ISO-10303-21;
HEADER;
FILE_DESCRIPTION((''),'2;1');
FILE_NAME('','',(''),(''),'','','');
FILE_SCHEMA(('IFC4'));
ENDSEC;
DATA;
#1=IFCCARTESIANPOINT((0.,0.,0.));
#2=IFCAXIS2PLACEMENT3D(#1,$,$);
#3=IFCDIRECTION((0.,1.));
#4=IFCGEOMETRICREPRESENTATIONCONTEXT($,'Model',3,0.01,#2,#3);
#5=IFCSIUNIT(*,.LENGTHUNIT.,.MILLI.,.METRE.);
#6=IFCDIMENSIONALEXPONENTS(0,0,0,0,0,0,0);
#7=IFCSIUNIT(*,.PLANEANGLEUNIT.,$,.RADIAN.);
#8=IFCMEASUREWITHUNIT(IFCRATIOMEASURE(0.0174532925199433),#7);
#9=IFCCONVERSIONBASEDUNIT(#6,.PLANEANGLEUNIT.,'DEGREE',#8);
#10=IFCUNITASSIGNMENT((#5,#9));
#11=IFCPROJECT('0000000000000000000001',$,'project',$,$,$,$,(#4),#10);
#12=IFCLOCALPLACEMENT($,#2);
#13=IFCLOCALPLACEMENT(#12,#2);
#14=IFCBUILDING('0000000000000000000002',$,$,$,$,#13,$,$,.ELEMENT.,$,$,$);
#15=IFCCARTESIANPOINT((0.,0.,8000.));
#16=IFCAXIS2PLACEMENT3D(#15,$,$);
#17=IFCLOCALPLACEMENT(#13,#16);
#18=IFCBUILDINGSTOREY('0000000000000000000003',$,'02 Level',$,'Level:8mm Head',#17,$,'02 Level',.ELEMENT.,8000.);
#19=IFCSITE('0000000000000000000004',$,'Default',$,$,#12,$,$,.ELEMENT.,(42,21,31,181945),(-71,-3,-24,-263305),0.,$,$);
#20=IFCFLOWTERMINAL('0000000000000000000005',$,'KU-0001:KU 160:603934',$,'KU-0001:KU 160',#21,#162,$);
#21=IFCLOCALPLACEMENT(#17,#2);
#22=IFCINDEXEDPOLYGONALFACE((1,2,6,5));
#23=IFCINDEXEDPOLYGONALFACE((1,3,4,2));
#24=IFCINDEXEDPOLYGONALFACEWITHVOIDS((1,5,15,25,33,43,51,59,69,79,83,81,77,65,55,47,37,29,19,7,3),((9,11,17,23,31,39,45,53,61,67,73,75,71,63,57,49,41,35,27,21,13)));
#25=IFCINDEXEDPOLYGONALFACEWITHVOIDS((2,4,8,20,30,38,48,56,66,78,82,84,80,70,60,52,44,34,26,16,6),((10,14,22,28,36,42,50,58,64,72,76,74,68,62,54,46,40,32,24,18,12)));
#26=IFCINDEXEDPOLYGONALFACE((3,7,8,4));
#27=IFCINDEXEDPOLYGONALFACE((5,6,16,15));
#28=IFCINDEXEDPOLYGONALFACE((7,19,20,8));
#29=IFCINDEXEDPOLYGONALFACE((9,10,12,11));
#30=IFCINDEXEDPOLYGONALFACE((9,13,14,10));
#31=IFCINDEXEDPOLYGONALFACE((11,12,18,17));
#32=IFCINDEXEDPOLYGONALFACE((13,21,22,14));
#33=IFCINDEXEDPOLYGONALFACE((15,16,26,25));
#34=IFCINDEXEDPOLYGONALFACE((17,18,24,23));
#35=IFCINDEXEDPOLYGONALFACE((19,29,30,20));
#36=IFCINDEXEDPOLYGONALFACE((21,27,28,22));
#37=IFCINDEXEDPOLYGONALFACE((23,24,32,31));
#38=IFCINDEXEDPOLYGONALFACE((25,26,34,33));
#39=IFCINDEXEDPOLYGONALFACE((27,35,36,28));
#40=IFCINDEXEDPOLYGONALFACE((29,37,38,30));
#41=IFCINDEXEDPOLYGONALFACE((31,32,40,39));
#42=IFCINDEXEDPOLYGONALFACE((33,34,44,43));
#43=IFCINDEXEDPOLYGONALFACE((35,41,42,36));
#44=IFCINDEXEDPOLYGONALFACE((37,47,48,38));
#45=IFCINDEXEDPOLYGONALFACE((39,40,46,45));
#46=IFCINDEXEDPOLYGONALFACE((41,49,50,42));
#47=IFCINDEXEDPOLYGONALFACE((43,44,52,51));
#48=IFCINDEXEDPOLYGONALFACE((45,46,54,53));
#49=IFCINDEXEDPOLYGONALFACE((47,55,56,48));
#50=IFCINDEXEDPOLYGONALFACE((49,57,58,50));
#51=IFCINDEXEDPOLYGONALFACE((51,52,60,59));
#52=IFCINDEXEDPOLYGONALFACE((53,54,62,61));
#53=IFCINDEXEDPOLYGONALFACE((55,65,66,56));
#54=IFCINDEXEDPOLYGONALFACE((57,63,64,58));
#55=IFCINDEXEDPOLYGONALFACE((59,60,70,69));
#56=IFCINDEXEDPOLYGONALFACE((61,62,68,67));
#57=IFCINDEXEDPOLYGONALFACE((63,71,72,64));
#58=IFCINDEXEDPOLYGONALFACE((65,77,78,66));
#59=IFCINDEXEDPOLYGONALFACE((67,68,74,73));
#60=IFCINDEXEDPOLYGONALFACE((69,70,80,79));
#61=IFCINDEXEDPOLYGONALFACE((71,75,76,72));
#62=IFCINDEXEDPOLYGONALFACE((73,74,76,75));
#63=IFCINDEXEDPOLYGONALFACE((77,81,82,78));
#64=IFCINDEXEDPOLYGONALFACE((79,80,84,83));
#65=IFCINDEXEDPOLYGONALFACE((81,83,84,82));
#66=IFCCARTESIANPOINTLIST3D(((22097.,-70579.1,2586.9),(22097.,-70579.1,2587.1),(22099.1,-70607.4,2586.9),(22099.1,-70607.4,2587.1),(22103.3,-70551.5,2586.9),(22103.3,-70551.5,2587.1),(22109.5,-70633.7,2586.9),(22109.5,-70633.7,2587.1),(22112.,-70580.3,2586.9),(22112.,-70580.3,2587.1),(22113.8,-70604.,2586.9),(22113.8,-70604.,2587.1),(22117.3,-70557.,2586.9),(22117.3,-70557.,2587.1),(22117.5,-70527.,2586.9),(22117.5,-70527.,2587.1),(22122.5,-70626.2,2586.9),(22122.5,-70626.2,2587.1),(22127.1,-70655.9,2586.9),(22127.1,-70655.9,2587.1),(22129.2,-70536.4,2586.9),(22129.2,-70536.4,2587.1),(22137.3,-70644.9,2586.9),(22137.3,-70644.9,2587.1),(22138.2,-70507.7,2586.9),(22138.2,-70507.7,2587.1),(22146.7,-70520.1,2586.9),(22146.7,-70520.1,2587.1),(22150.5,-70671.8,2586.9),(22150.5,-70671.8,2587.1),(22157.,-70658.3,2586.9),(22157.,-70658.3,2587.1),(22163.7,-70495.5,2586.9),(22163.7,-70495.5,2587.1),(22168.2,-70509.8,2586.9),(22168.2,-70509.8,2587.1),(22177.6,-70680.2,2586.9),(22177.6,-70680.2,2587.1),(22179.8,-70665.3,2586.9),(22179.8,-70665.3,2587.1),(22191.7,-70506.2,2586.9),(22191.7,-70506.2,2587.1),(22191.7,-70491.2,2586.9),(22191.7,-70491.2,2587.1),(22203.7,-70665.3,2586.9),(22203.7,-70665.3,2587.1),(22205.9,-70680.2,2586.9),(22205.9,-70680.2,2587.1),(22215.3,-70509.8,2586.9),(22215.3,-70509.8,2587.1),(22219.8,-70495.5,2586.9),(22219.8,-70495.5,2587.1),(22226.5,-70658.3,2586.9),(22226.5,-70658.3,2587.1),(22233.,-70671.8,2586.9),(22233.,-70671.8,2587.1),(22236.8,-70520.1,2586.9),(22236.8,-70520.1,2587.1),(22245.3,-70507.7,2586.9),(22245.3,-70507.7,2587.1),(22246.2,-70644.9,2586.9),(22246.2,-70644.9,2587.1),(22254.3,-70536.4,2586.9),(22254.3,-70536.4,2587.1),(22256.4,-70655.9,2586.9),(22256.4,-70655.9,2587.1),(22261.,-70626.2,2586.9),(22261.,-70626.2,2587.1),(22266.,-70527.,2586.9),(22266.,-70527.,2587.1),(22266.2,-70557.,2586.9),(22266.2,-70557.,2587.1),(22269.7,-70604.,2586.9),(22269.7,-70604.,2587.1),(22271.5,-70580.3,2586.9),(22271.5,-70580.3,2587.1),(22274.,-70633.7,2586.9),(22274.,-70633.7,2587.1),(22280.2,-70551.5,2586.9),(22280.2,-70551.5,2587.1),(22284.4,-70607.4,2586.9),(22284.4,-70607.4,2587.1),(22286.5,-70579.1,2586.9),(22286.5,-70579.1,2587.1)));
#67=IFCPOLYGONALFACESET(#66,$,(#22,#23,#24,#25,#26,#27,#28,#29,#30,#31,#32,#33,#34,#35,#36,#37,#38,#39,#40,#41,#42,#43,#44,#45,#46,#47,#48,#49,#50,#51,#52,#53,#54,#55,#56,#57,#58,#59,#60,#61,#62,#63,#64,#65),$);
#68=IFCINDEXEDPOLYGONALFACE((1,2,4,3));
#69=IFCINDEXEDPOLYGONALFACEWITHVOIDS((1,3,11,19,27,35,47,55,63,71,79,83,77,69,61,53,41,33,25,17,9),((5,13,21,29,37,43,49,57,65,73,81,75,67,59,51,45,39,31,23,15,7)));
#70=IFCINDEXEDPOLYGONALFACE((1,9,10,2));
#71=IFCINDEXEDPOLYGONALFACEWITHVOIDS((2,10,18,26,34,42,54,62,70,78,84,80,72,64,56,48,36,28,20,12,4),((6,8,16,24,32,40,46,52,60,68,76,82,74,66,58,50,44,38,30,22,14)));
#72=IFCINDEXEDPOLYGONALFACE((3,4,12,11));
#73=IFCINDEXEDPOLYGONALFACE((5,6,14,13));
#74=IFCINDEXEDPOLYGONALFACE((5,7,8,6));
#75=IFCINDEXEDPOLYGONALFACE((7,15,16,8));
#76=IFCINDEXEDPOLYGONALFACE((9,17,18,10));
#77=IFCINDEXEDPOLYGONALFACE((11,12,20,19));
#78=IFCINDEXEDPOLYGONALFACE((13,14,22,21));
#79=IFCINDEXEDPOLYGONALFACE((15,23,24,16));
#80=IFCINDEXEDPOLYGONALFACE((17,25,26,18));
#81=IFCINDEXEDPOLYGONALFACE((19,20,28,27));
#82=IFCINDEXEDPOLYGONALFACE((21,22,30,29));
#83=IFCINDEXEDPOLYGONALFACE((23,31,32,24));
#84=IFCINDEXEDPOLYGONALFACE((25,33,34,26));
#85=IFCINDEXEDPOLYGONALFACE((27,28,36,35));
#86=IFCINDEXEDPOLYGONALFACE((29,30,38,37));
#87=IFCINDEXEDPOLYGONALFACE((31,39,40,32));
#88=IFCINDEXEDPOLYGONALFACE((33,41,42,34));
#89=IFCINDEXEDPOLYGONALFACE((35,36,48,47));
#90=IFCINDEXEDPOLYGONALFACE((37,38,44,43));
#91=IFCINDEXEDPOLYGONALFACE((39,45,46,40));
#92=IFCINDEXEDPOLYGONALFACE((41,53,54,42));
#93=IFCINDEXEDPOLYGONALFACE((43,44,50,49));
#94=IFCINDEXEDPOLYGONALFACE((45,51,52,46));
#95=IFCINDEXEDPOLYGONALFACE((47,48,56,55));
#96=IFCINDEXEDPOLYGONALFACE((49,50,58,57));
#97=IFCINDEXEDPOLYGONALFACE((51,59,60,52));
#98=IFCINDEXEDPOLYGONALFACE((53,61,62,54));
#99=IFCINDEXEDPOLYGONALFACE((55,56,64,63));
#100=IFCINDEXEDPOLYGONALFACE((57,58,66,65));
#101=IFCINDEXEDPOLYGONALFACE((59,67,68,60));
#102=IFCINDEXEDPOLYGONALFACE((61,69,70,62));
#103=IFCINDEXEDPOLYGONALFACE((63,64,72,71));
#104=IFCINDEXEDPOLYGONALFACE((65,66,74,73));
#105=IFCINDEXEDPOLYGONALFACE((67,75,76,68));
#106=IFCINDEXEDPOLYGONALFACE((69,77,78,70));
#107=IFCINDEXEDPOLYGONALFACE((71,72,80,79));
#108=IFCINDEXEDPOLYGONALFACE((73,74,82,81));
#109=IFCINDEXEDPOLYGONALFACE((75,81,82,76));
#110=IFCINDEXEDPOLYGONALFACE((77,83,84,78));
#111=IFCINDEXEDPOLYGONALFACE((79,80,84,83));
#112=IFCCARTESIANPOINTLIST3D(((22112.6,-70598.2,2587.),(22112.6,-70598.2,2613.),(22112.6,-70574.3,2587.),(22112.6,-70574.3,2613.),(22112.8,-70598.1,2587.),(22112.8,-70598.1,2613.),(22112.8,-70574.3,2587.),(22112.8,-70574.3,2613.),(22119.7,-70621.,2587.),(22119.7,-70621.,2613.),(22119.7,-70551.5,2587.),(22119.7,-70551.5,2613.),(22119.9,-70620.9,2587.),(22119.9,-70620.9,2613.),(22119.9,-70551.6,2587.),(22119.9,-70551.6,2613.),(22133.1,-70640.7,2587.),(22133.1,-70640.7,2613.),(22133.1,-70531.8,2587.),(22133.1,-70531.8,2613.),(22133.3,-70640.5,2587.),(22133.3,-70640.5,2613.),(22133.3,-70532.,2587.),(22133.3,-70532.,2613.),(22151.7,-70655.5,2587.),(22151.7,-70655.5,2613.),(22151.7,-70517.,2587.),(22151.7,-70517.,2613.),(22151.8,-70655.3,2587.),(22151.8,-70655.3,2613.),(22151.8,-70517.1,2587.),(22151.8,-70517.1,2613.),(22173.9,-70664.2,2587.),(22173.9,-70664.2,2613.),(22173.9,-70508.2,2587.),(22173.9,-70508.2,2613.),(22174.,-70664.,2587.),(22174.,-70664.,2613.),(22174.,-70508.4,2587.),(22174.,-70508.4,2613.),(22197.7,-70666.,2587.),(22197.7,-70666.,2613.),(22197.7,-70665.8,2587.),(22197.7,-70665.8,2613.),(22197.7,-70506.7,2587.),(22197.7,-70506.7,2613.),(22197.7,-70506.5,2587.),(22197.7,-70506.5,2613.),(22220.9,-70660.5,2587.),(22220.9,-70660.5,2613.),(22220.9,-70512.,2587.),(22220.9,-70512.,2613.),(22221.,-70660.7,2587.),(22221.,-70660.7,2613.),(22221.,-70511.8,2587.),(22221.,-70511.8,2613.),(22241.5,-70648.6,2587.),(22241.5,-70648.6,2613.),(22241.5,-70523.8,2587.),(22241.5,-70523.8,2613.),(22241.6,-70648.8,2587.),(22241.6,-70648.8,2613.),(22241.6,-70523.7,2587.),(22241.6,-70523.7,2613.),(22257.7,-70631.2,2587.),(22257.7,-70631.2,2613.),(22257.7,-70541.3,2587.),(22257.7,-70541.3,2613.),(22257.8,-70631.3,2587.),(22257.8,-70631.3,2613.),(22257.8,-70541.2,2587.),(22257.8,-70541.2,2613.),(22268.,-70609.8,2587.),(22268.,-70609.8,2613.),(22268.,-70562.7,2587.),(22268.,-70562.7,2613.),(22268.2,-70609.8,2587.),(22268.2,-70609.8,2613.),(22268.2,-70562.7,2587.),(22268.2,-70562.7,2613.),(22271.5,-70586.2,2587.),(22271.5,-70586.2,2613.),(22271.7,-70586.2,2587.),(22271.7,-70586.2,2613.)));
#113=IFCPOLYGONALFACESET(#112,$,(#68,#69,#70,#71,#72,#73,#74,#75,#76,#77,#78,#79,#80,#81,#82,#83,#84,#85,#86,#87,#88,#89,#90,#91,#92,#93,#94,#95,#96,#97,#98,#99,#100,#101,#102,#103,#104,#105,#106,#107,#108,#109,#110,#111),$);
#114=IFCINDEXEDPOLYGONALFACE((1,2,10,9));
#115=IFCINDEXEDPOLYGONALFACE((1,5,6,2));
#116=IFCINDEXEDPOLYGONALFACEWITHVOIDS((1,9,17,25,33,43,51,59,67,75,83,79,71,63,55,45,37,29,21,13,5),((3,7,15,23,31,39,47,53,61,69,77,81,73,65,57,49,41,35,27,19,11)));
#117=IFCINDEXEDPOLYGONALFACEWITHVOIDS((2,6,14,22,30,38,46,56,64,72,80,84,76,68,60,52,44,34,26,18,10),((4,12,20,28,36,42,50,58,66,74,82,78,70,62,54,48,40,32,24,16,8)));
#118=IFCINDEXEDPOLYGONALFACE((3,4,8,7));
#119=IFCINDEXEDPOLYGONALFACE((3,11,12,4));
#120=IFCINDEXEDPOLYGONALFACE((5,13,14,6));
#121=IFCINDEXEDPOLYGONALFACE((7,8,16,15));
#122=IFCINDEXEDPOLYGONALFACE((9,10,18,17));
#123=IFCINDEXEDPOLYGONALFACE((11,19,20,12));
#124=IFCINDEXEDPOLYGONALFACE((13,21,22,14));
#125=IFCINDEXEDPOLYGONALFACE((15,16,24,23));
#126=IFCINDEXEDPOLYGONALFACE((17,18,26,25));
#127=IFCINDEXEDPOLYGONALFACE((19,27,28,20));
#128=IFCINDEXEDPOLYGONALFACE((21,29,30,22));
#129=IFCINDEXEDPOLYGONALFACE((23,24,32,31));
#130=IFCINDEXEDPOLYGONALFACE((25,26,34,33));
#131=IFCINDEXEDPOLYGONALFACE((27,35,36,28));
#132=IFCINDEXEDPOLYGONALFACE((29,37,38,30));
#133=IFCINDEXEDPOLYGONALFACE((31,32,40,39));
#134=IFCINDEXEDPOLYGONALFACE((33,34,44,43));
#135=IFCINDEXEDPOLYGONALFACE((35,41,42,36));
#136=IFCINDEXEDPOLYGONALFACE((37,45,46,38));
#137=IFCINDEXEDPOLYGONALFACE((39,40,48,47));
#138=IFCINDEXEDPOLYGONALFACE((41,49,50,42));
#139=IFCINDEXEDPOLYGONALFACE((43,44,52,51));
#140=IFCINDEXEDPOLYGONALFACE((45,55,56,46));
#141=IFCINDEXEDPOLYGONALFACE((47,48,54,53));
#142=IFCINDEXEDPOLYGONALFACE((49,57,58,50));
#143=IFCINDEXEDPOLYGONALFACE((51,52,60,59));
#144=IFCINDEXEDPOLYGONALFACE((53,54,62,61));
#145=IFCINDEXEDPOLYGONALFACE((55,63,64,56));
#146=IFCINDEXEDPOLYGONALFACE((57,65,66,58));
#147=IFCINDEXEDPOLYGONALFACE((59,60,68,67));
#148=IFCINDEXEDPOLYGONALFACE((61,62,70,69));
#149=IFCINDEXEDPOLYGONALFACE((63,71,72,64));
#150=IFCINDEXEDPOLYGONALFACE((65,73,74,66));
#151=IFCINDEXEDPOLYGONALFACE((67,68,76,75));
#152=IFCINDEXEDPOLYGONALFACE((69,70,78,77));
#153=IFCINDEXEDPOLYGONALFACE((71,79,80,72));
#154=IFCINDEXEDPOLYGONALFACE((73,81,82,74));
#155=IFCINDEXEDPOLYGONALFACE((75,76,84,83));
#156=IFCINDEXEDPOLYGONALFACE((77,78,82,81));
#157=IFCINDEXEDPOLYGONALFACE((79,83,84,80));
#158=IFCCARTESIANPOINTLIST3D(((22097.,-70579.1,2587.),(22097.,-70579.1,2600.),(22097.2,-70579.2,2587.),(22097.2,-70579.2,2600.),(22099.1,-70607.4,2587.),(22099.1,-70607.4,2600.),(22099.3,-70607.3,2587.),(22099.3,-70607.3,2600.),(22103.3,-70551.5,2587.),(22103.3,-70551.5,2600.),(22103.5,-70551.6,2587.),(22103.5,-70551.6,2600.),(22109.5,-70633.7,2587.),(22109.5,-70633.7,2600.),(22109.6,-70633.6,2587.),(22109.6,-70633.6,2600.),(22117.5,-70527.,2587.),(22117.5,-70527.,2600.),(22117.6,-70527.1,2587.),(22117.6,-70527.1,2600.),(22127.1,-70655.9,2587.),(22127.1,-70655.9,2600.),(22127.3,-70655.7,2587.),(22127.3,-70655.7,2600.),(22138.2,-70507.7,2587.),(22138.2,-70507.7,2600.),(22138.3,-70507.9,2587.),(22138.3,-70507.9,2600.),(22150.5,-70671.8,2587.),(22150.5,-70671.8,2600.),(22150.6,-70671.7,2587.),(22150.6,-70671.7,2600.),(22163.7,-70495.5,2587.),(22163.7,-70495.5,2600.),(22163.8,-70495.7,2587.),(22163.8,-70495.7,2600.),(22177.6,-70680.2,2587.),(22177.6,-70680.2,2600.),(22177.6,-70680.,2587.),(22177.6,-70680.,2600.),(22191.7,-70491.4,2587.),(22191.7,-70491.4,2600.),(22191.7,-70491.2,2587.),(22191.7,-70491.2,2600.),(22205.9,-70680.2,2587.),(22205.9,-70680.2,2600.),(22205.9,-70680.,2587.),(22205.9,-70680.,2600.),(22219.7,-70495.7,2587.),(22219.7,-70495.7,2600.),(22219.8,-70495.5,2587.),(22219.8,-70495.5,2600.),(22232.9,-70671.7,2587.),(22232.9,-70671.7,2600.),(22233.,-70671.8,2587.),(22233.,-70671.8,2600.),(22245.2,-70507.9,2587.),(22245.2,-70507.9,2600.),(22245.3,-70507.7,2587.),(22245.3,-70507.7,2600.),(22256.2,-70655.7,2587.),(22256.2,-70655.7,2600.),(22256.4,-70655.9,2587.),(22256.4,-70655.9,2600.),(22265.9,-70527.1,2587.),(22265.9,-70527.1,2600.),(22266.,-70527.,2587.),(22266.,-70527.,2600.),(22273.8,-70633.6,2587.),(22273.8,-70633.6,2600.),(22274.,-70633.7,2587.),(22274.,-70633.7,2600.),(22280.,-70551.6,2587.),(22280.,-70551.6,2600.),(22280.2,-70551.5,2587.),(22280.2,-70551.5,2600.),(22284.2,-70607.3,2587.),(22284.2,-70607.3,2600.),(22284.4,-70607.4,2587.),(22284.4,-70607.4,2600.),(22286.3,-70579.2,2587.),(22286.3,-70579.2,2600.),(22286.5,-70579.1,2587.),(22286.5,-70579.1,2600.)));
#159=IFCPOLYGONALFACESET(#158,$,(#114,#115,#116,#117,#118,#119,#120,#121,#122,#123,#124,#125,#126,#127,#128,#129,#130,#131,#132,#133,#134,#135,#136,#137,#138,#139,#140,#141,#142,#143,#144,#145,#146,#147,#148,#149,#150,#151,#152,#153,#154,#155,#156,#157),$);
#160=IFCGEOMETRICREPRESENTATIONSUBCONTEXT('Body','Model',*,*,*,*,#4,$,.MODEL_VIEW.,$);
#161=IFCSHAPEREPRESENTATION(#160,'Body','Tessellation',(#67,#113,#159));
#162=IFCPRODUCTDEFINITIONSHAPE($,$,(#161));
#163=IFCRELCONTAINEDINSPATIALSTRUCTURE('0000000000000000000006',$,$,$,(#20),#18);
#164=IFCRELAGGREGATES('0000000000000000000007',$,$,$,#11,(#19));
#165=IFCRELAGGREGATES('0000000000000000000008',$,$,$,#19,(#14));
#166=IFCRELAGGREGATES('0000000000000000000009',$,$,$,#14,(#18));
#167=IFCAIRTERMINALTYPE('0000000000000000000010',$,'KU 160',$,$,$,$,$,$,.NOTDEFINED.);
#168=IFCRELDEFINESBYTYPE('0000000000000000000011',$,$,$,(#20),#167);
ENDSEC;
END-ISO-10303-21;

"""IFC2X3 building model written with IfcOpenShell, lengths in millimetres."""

from ifc_helpers import new_model, entity, si_unit, converted_unit, direction, frame, frame_2d, origin, place, context, subcontext, project, spatial, hollow_circle, extrude, source, transform, mapped, type_object, type_shapes, element, save


model = new_model("IFC2X3")

# Units and contexts
model_context = context("Model", 3, precision=0.01, world=origin(), true_north=direction((0.0, 1.0)))
body_context = subcontext(model_context, "Body", "Model", "MODEL_VIEW")
ifc_project = project(units=[si_unit("LENGTHUNIT", "METRE", prefix="MILLI"), converted_unit("PLANEANGLEUNIT", "DEGREE", entity("IfcRatioMeasure", 0.0174532925199433), si_unit("PLANEANGLEUNIT", "RADIAN"), dimensions=[0, 0, 0, 0, 0, 0, 0])], contexts=[model_context])

# Site, building, storey
site_placement = place(None, origin())
site = spatial("IfcSite", under=ifc_project, at=site_placement, Name="Default", CompositionType="ELEMENT", RefLatitude=(42, 21, 31, 181945), RefLongitude=(-71, -3, -24, -263305), RefElevation=0.0)
building_placement = place(site_placement, origin())
building = spatial("IfcBuilding", under=site, at=building_placement, CompositionType="ELEMENT")
storey_placement = place(building_placement, frame((0.0, 0.0, 8000.0)))
storey = spatial("IfcBuildingStorey", under=building, at=storey_placement, Name="02 Level", ObjectType="Level:8mm Head", LongName="02 Level", CompositionType="ELEMENT", Elevation=8000.0)

# Flow terminal
air_terminal_type_1 = type_object("IfcAirTerminalType", Name="KU 160", PredefinedType="NOTDEFINED")
shared_shape_1 = source(origin(), body_context, "Body", "SweptSolid", [
    extrude(hollow_circle(Radius=95.0, WallThickness=15.0, at=frame_2d((0.0, 0.0), x_axis=(1.0, 0.0))), frame((12.9, 0.0, 0.0), z_axis=(1.0, 0.0, 0.0), x_axis=(0.0, 1.0, 0.0)), (0.0, 0.0, 1.0), 0.2),
    extrude(hollow_circle(Radius=80.0, WallThickness=0.2, at=frame_2d((0.0, 0.0), x_axis=(1.0, 0.0))), frame((-13.0, 0.0, 0.0), z_axis=(1.0, 0.0, 0.0), x_axis=(0.0, 0.0, 1.0)), (0.0, 0.0, 1.0), 26.0),
    extrude(hollow_circle(Radius=95.0, WallThickness=0.2, at=frame_2d((0.0, 0.0), x_axis=(1.0, 0.0))), frame((0.0, 0.0, 0.0), z_axis=(1.0, 0.0, 0.0), x_axis=(0.0, 1.0, 0.0)), (0.0, 0.0, 1.0), 13.0),
])
type_shapes(air_terminal_type_1, [shared_shape_1])
for number, where, z_axis, x_axis, name in (
    (1, (22191.7, -70586.2, 2600.0), (1.0, 0.0, 0.0), (0.0, 0.0, -1.0), "KU-0001:KU 160:603934"),
):
    element("IfcFlowTerminal", number, at=place(storey_placement, frame(where, z_axis=z_axis, x_axis=x_axis)), inside=storey, type_object=air_terminal_type_1, Name=name, ObjectType="KU-0001:KU 160", context=body_context, shape_type="MappedRepresentation", body=[
        mapped(shared_shape_1, transform((0.0, 0.0, 0.0), scale=1.0)),
    ])

save(model, "model.ifc")
